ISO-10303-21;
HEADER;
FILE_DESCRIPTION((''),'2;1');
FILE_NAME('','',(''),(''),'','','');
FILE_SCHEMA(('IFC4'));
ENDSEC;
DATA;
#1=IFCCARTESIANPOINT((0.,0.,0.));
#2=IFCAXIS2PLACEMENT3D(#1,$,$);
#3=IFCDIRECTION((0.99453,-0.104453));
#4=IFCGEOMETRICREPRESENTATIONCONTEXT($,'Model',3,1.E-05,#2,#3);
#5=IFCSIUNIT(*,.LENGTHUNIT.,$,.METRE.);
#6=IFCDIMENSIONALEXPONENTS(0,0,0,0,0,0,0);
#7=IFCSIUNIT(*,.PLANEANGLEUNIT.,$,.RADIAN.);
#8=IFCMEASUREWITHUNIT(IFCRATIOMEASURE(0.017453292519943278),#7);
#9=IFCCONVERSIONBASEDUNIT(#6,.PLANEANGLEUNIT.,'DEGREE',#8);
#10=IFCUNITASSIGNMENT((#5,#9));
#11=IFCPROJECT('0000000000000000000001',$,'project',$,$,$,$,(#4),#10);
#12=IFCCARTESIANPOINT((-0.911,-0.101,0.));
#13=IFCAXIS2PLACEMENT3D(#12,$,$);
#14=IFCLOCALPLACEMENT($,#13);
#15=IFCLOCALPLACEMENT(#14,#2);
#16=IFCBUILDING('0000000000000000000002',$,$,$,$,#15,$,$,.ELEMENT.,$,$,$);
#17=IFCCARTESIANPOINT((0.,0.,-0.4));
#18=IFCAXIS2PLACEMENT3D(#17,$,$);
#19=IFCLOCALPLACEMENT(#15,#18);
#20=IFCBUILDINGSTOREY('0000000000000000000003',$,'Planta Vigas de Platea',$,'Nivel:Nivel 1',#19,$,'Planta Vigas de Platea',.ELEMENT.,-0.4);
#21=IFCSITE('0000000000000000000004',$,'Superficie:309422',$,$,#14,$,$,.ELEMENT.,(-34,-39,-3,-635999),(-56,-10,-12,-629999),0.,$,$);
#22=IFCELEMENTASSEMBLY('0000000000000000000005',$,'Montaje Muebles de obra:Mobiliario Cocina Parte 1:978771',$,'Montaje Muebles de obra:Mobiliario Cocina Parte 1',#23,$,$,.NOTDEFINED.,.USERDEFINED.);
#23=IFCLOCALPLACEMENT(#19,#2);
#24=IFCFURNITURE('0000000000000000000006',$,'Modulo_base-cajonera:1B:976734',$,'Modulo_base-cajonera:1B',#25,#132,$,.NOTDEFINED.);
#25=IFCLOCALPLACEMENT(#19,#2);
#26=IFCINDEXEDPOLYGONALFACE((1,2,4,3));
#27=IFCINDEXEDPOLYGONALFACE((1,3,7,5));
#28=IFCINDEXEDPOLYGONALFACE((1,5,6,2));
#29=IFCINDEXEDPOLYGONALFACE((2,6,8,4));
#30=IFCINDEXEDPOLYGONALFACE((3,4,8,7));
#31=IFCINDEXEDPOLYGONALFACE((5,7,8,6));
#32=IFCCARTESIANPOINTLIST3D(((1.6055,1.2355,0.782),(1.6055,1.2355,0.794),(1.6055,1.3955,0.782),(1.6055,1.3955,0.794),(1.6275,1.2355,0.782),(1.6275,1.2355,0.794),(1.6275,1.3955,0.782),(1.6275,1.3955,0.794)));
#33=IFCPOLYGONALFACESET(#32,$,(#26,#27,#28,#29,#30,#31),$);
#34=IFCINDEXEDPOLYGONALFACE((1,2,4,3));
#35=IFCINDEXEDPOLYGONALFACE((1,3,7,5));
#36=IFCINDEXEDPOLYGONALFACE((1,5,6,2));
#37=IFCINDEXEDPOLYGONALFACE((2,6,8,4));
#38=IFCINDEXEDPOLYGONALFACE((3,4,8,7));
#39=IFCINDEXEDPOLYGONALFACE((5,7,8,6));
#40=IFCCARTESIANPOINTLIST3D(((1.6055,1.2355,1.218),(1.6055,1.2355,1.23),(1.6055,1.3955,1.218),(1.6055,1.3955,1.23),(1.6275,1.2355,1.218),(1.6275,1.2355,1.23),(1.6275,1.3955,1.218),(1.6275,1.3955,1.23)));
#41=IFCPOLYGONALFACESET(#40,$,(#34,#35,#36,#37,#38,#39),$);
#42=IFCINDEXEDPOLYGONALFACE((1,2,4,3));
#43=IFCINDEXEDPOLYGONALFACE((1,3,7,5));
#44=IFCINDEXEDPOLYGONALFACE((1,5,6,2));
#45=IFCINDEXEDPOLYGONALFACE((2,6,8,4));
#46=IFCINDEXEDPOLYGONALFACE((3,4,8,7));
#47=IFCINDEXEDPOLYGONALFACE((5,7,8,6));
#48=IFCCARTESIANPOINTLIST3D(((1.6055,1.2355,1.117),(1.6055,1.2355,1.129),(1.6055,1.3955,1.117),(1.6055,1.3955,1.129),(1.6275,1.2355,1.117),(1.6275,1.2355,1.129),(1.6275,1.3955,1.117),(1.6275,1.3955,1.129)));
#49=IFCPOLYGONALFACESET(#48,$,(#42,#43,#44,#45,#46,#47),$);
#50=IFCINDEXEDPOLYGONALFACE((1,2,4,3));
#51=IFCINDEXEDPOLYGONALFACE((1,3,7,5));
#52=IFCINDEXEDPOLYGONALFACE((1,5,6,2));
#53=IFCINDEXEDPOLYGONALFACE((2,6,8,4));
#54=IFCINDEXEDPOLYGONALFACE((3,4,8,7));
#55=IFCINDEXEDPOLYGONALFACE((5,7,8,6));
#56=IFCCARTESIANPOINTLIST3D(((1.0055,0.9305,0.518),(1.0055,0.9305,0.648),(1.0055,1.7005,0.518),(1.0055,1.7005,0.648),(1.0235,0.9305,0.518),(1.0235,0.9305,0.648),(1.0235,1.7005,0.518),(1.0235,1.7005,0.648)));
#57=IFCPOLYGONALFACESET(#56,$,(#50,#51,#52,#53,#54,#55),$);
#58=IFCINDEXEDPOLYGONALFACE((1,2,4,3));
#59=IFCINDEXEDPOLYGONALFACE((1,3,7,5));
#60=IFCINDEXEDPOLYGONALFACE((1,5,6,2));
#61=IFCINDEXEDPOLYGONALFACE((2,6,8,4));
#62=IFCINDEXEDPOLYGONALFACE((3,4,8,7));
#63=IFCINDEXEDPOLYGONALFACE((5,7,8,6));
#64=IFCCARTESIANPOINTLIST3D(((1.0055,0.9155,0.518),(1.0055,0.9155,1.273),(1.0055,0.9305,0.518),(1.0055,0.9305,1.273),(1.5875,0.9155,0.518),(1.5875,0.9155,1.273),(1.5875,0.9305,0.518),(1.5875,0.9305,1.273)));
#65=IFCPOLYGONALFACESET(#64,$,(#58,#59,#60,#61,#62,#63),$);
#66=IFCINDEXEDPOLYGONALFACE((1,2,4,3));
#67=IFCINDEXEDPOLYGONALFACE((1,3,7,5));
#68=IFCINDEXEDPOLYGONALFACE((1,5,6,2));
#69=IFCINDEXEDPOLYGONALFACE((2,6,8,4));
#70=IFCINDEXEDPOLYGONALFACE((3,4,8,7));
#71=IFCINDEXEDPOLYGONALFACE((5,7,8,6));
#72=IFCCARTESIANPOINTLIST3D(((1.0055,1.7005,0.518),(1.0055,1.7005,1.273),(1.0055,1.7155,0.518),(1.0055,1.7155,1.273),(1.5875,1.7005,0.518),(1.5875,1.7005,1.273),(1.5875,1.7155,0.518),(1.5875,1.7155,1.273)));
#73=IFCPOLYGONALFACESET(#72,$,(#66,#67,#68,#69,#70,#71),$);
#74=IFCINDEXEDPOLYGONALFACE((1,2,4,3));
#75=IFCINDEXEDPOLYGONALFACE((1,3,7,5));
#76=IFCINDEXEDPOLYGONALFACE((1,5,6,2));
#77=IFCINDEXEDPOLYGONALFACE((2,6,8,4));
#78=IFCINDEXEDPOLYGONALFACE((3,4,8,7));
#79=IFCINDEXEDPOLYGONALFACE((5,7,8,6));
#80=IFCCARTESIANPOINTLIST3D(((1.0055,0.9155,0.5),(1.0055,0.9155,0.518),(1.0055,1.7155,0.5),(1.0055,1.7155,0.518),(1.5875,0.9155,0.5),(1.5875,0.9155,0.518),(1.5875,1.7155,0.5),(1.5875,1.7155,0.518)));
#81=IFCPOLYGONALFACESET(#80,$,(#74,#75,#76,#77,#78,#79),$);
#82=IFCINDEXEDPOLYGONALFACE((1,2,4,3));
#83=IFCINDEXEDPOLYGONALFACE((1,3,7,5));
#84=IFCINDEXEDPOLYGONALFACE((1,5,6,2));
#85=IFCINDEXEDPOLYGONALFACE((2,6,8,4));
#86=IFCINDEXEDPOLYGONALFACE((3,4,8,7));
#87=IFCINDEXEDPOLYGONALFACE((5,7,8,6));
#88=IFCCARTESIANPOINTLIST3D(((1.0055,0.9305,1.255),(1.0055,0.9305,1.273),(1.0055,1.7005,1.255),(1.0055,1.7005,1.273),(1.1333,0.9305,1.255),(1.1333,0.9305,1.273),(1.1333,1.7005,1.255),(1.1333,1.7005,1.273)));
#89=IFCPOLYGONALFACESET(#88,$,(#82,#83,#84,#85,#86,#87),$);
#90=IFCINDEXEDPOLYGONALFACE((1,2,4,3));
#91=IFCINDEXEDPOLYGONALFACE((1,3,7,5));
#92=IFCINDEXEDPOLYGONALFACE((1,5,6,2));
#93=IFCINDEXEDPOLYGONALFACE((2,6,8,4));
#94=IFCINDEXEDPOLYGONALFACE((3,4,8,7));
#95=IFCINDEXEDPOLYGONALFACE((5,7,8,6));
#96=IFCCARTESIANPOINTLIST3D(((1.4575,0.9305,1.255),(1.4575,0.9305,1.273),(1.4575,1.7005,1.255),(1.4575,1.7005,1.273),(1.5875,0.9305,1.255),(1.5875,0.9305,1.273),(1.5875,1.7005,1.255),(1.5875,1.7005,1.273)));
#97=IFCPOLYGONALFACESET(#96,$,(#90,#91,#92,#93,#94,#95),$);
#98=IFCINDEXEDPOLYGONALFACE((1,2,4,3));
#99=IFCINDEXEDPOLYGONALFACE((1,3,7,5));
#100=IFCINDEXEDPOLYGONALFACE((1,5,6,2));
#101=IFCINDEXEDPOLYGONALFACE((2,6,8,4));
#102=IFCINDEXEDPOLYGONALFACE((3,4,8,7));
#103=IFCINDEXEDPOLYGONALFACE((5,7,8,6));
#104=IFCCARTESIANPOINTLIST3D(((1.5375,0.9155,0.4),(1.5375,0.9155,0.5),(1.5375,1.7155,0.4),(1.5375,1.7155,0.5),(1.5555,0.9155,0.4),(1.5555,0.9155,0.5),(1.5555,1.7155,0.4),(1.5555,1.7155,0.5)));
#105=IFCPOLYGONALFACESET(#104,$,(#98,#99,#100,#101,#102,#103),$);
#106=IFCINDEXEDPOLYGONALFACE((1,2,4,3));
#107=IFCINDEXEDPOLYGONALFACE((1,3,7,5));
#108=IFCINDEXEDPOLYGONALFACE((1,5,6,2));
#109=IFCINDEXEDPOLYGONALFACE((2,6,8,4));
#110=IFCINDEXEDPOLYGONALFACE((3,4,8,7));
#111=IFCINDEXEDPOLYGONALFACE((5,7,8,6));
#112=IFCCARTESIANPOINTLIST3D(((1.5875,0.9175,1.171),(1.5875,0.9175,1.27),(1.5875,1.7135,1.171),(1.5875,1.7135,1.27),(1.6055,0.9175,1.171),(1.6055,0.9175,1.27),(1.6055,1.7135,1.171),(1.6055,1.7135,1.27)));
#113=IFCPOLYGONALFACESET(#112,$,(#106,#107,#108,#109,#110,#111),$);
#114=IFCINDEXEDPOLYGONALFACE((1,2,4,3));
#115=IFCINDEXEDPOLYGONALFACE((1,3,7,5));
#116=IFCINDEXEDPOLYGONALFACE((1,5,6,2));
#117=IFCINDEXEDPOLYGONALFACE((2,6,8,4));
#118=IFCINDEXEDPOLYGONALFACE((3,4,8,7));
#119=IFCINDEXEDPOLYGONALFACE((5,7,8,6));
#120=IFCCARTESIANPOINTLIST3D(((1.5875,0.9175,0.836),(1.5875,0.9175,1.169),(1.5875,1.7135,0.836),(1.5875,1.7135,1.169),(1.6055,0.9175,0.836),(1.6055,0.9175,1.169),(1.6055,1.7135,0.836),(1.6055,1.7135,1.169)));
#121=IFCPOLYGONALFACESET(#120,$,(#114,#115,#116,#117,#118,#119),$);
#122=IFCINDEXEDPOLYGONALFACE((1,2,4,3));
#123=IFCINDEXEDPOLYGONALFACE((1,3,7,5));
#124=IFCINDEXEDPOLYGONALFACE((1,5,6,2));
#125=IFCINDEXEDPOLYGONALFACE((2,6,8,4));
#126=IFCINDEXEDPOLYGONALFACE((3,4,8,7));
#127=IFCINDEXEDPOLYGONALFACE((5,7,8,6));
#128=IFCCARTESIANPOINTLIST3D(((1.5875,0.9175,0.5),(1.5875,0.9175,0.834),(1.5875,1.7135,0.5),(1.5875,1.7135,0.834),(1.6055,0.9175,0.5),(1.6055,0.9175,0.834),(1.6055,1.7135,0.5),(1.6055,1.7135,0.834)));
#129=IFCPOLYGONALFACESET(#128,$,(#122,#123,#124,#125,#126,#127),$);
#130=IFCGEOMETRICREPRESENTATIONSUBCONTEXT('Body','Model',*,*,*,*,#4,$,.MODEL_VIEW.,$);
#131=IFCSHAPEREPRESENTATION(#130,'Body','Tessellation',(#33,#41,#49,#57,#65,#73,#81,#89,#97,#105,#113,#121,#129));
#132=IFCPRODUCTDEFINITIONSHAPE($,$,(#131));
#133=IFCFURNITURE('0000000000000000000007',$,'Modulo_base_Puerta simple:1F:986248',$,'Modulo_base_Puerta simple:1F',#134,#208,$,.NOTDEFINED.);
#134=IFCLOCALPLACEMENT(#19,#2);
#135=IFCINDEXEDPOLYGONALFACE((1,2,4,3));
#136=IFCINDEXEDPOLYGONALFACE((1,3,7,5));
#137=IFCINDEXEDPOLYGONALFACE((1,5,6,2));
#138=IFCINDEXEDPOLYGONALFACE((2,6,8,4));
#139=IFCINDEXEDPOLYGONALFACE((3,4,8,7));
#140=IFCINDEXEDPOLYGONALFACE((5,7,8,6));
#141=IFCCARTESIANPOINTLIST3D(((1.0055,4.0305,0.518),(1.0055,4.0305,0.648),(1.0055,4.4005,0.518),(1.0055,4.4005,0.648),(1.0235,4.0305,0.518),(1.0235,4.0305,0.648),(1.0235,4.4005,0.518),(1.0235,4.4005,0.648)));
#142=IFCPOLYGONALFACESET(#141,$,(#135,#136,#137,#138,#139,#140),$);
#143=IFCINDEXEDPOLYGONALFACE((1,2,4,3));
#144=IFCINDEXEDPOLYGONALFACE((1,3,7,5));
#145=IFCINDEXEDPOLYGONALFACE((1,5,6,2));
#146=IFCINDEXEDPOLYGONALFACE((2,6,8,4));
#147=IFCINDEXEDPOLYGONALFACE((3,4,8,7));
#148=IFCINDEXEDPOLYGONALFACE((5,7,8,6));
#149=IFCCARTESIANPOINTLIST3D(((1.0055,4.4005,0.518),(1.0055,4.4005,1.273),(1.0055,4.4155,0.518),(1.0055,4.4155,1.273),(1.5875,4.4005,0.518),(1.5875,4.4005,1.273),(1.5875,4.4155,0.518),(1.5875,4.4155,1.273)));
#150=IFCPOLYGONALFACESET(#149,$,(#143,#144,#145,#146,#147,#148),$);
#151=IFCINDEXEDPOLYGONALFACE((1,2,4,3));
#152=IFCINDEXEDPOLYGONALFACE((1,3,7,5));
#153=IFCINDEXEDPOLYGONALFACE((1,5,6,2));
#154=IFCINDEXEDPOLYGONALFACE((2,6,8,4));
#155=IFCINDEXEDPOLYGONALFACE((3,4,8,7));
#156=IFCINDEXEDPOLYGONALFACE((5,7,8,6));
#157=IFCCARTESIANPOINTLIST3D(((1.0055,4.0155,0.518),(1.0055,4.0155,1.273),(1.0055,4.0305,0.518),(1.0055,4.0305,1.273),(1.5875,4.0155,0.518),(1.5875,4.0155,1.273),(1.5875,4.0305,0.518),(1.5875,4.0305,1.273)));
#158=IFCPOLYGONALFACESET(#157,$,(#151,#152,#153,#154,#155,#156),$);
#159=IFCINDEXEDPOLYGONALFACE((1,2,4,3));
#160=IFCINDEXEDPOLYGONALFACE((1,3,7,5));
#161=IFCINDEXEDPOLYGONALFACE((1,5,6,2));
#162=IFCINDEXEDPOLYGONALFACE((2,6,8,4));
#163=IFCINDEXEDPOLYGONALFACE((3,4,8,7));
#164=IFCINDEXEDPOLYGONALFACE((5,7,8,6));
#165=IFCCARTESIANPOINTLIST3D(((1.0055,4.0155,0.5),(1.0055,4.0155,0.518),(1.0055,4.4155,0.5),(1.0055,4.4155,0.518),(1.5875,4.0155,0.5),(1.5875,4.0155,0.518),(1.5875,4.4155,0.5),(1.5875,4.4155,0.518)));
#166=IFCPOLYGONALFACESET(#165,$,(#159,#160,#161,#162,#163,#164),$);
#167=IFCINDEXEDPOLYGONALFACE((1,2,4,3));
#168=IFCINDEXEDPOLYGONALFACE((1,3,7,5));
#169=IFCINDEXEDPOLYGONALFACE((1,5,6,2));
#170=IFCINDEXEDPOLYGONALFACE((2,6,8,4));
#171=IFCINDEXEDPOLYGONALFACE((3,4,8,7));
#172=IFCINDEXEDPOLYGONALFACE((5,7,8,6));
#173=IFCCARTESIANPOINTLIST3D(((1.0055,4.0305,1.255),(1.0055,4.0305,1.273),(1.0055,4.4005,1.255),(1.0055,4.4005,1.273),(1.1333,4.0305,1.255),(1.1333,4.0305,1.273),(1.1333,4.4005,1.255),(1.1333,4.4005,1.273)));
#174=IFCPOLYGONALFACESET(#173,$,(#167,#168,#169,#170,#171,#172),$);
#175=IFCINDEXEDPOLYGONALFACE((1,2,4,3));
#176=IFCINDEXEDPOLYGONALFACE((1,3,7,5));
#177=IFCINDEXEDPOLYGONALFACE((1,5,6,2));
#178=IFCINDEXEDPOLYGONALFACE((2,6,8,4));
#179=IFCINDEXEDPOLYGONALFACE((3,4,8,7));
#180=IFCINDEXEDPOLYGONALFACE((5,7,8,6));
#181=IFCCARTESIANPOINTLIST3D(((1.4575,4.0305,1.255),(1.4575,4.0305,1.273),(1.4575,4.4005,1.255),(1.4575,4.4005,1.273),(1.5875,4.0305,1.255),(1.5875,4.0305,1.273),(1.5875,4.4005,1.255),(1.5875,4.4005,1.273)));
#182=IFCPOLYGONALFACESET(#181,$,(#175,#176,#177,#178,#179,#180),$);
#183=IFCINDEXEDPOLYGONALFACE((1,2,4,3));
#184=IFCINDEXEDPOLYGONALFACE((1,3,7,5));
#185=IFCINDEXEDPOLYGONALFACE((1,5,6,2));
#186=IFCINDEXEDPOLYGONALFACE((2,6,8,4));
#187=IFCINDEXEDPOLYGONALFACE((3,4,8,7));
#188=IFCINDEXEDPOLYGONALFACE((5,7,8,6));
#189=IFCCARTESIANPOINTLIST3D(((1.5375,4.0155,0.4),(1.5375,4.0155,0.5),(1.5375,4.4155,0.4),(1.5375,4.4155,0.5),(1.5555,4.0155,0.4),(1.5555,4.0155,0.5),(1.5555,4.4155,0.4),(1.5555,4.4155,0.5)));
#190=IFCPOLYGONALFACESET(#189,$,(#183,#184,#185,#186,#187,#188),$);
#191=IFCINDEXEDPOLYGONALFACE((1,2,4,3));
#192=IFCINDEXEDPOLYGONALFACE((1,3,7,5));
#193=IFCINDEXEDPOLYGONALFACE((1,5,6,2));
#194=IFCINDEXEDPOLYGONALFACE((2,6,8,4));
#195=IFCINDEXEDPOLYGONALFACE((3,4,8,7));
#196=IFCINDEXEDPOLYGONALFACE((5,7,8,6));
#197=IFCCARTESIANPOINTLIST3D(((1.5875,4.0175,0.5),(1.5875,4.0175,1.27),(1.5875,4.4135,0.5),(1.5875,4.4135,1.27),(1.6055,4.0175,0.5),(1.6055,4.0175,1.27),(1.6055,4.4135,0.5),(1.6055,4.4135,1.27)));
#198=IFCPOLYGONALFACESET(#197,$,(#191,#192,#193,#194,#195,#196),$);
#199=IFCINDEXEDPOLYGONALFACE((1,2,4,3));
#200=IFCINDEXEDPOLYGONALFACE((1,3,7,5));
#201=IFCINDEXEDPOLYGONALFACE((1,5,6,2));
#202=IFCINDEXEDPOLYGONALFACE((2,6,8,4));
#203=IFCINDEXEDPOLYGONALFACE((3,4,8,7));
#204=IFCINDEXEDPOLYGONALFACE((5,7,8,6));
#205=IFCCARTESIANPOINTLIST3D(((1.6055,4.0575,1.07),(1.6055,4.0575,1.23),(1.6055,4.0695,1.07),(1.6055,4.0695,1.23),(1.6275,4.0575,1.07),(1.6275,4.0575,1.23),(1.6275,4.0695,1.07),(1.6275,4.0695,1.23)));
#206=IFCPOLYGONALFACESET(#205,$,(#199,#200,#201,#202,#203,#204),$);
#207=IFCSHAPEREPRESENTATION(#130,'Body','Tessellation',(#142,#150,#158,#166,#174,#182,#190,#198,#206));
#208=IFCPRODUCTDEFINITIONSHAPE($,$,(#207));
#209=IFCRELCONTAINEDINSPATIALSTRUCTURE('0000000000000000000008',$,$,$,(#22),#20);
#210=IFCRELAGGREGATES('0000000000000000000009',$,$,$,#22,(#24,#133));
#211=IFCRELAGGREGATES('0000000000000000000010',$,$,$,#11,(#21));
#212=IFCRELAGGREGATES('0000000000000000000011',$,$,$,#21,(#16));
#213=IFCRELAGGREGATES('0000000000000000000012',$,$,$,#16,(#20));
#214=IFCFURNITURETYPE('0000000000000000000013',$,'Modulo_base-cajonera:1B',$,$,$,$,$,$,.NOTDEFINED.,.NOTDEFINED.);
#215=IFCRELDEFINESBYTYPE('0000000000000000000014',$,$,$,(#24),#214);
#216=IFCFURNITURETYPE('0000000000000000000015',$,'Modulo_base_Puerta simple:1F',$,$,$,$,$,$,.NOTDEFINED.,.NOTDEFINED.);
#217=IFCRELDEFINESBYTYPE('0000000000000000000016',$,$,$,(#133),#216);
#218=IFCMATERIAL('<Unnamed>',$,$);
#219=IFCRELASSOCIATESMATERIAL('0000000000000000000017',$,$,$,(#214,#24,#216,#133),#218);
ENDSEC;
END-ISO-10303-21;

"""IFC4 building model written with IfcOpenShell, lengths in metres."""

from ifc_helpers import new_model, entity, si_unit, converted_unit, direction, frame, frame_2d, origin, origin_2d_with_axis, place, context, subcontext, project, spatial, rectangle, extrude, source, transform, mapped, material, type_object, type_shapes, element, aggregate, save


model = new_model("IFC4")

# Units and contexts
model_context = context("Model", 3, precision=1e-05, world=origin(), true_north=direction((0.99453, -0.104453)))
body_context = subcontext(model_context, "Body", "Model", "MODEL_VIEW")
ifc_project = project(units=[si_unit("LENGTHUNIT", "METRE"), converted_unit("PLANEANGLEUNIT", "DEGREE", entity("IfcRatioMeasure", 0.017453292519943278), si_unit("PLANEANGLEUNIT", "RADIAN"), dimensions=[0, 0, 0, 0, 0, 0, 0])], contexts=[model_context])

# Site, building, storey
site_placement = place(None, frame((-0.911, -0.101, 0.0)))
site = spatial("IfcSite", under=ifc_project, at=site_placement, Name="Superficie:309422", CompositionType="ELEMENT", RefLatitude=(-34, -39, -3, -635999), RefLongitude=(-56, -10, -12, -629999), RefElevation=0.0)
building_placement = place(site_placement, origin())
building = spatial("IfcBuilding", under=site, at=building_placement, CompositionType="ELEMENT")
storey_placement = place(building_placement, frame((0.0, 0.0, -0.4)))
storey = spatial("IfcBuildingStorey", under=building, at=storey_placement, Name="Planta Vigas de Platea", ObjectType="Nivel:Nivel 1", LongName="Planta Vigas de Platea", CompositionType="ELEMENT", Elevation=-0.4)

# Shared definitions
ifc_material_1 = material(Name="<Unnamed>")

# Element assembly, furniture
assembly_placement = place(storey_placement, origin())
assembly = element("IfcElementAssembly", 1, at=assembly_placement, inside=storey, Name="Montaje Muebles de obra:Mobiliario Cocina Parte 1:978771", ObjectType="Montaje Muebles de obra:Mobiliario Cocina Parte 1", AssemblyPlace="NOTDEFINED", PredefinedType="USERDEFINED")
furniture_type_1 = type_object("IfcFurnitureType", Name="Modulo_base-cajonera:1B", AssemblyPlace="NOTDEFINED", PredefinedType="NOTDEFINED", material=ifc_material_1)
shared_shape_1 = source(origin(), body_context, "Body", "SweptSolid", [
    extrude(rectangle(XDim=0.022, YDim=0.16, at=origin_2d_with_axis()), frame((0.611, 0.4, 0.382), z_axis=(0.0, 0.0, 1.0), x_axis=(-1.0, 0.0, 0.0)), (0.0, 0.0, 1.0), 0.012),
    extrude(rectangle(XDim=0.022, YDim=0.16, at=origin_2d_with_axis()), frame((0.611, 0.4, 0.818), z_axis=(0.0, 0.0, 1.0), x_axis=(-1.0, 0.0, 0.0)), (0.0, 0.0, 1.0), 0.012),
    extrude(rectangle(XDim=0.022, YDim=0.16, at=origin_2d_with_axis()), frame((0.611, 0.4, 0.717), z_axis=(0.0, 0.0, 1.0), x_axis=(-1.0, 0.0, 0.0)), (0.0, 0.0, 1.0), 0.012),
    extrude(rectangle(XDim=0.77, YDim=0.018, at=frame_2d((0.0, 0.0), x_axis=(1.0, 0.0))), frame((0.009, 0.4, 0.118), z_axis=(0.0, 0.0, 1.0), x_axis=(0.0, -1.0, 0.0)), (0.0, 0.0, 1.0), 0.13),
    extrude(rectangle(XDim=0.015, YDim=0.582, at=frame_2d((0.0, 0.0), x_axis=(1.0, 0.0))), frame((0.291, 0.0075, 0.118), z_axis=(0.0, 0.0, 1.0), x_axis=(0.0, -1.0, 0.0)), (0.0, 0.0, 1.0), 0.755),
    extrude(rectangle(XDim=0.015, YDim=0.582, at=frame_2d((0.0, 0.0), x_axis=(1.0, 0.0))), frame((0.291, 0.7925, 0.118), z_axis=(0.0, 0.0, 1.0), x_axis=(0.0, 1.0, 0.0)), (0.0, 0.0, 1.0), 0.755),
    extrude(rectangle(XDim=0.8, YDim=0.582, at=frame_2d((0.0, 0.0), x_axis=(1.0, 0.0))), frame((0.291, 0.4, 0.1), z_axis=(0.0, 0.0, 1.0), x_axis=(0.0, -1.0, 0.0)), (0.0, 0.0, 1.0), 0.018),
    extrude(rectangle(XDim=0.77, YDim=0.1278, at=frame_2d((0.0, 0.0), x_axis=(1.0, 0.0))), frame((0.0639, 0.4, 0.855), z_axis=(0.0, 0.0, 1.0), x_axis=(0.0, -1.0, 0.0)), (0.0, 0.0, 1.0), 0.018),
    extrude(rectangle(XDim=0.77, YDim=0.13, at=frame_2d((0.0, 0.0), x_axis=(1.0, 0.0))), frame((0.517, 0.4, 0.855), z_axis=(0.0, 0.0, 1.0), x_axis=(0.0, -1.0, 0.0)), (0.0, 0.0, 1.0), 0.018),
    extrude(rectangle(XDim=0.018, YDim=0.8, at=frame_2d((0.0, 0.0), x_axis=(1.0, 0.0))), frame((0.541, 0.4, 0.0)), (0.0, 0.0, 1.0), 0.1),
    extrude(rectangle(XDim=0.018, YDim=0.796, at=frame_2d((0.0, 0.0), x_axis=(1.0, 0.0))), frame((0.591, 0.4, 0.771), z_axis=(0.0, 0.0, 1.0), x_axis=(-1.0, 0.0, 0.0)), (0.0, 0.0, 1.0), 0.099),
    extrude(rectangle(XDim=0.018, YDim=0.796, at=frame_2d((0.0, 0.0), x_axis=(1.0, 0.0))), frame((0.591, 0.4, 0.436), z_axis=(0.0, 0.0, 1.0), x_axis=(-1.0, 0.0, 0.0)), (0.0, 0.0, 1.0), 0.333),
    extrude(rectangle(XDim=0.018, YDim=0.796, at=frame_2d((0.0, 0.0), x_axis=(1.0, 0.0))), frame((0.591, 0.4, 0.1), z_axis=(0.0, 0.0, 1.0), x_axis=(-1.0, 0.0, 0.0)), (0.0, 0.0, 1.0), 0.334),
])
type_shapes(furniture_type_1, [shared_shape_1])
furniture_1_placement = place(assembly_placement, frame((1.0055, 0.9155, 0.4)))
furniture_1 = element("IfcFurniture", 2, at=furniture_1_placement, type_object=furniture_type_1, material=ifc_material_1, Name="Modulo_base-cajonera:1B:976734", ObjectType="Modulo_base-cajonera:1B", PredefinedType="NOTDEFINED", context=body_context, shape_type="MappedRepresentation", body=[
    mapped(shared_shape_1, transform((0.0, 0.0, 0.0), scale=1.0)),
])
furniture_type_2 = type_object("IfcFurnitureType", Name="Modulo_base_Puerta simple:1F", AssemblyPlace="NOTDEFINED", PredefinedType="NOTDEFINED", material=ifc_material_1)
shared_shape_2 = source(origin(), body_context, "Body", "SweptSolid", [
    extrude(rectangle(XDim=0.018, YDim=0.37, at=frame_2d((0.0, 0.0), x_axis=(1.0, 0.0))), frame((0.009, 0.2, 0.118)), (0.0, 0.0, 1.0), 0.13),
    extrude(rectangle(XDim=0.582, YDim=0.015, at=frame_2d((-0.0322, -0.0015), x_axis=(1.0, 0.0))), frame((0.3232, 0.394, 0.118)), (0.0, 0.0, 1.0), 0.755),
    extrude(rectangle(XDim=0.582, YDim=0.015, at=origin_2d_with_axis()), frame((0.291, 0.0075, 0.118), z_axis=(0.0, 0.0, 1.0), x_axis=(-1.0, 0.0, 0.0)), (0.0, 0.0, 1.0), 0.755),
    extrude(rectangle(XDim=0.582, YDim=0.4, at=frame_2d((-0.0322, -0.04), x_axis=(1.0, 0.0))), frame((0.3232, 0.24, 0.1)), (0.0, 0.0, 1.0), 0.018),
    extrude(rectangle(XDim=0.1278, YDim=0.37, at=frame_2d((0.0, 0.0), x_axis=(1.0, 0.0))), frame((0.0639, 0.2, 0.855)), (0.0, 0.0, 1.0), 0.018),
    extrude(rectangle(XDim=0.13, YDim=0.37, at=frame_2d((0.0, 0.0), x_axis=(1.0, 0.0))), frame((0.517, 0.2, 0.855)), (0.0, 0.0, 1.0), 0.018),
    extrude(rectangle(XDim=0.4, YDim=0.018, at=frame_2d((0.0, 0.0), x_axis=(1.0, 0.0))), frame((0.541, 0.2, 0.0), z_axis=(0.0, 0.0, 1.0), x_axis=(0.0, -1.0, 0.0)), (0.0, 0.0, 1.0), 0.1),
    extrude(rectangle(XDim=0.396, YDim=0.018, at=frame_2d((0.0, 0.0), x_axis=(1.0, 0.0))), frame((0.591, 0.2, 0.1), z_axis=(0.0, 0.0, 1.0), x_axis=(0.0, 1.0, 0.0)), (0.0, 0.0, 1.0), 0.77),
    extrude(rectangle(XDim=0.012, YDim=0.022, at=origin_2d_with_axis()), frame((0.611, 0.048, 0.67), z_axis=(0.0, 0.0, 1.0), x_axis=(0.0, 1.0, 0.0)), (0.0, 0.0, 1.0), 0.16),
])
type_shapes(furniture_type_2, [shared_shape_2])
furniture_2_placement = place(assembly_placement, frame((1.0055, 4.0155, 0.4)))
furniture_2 = element("IfcFurniture", 3, at=furniture_2_placement, type_object=furniture_type_2, material=ifc_material_1, Name="Modulo_base_Puerta simple:1F:986248", ObjectType="Modulo_base_Puerta simple:1F", PredefinedType="NOTDEFINED", context=body_context, shape_type="MappedRepresentation", body=[
    mapped(shared_shape_2, transform((0.0, 0.0, 0.0), scale=1.0)),
])
aggregate(assembly, [furniture_1, furniture_2])

save(model, "model.ifc")
